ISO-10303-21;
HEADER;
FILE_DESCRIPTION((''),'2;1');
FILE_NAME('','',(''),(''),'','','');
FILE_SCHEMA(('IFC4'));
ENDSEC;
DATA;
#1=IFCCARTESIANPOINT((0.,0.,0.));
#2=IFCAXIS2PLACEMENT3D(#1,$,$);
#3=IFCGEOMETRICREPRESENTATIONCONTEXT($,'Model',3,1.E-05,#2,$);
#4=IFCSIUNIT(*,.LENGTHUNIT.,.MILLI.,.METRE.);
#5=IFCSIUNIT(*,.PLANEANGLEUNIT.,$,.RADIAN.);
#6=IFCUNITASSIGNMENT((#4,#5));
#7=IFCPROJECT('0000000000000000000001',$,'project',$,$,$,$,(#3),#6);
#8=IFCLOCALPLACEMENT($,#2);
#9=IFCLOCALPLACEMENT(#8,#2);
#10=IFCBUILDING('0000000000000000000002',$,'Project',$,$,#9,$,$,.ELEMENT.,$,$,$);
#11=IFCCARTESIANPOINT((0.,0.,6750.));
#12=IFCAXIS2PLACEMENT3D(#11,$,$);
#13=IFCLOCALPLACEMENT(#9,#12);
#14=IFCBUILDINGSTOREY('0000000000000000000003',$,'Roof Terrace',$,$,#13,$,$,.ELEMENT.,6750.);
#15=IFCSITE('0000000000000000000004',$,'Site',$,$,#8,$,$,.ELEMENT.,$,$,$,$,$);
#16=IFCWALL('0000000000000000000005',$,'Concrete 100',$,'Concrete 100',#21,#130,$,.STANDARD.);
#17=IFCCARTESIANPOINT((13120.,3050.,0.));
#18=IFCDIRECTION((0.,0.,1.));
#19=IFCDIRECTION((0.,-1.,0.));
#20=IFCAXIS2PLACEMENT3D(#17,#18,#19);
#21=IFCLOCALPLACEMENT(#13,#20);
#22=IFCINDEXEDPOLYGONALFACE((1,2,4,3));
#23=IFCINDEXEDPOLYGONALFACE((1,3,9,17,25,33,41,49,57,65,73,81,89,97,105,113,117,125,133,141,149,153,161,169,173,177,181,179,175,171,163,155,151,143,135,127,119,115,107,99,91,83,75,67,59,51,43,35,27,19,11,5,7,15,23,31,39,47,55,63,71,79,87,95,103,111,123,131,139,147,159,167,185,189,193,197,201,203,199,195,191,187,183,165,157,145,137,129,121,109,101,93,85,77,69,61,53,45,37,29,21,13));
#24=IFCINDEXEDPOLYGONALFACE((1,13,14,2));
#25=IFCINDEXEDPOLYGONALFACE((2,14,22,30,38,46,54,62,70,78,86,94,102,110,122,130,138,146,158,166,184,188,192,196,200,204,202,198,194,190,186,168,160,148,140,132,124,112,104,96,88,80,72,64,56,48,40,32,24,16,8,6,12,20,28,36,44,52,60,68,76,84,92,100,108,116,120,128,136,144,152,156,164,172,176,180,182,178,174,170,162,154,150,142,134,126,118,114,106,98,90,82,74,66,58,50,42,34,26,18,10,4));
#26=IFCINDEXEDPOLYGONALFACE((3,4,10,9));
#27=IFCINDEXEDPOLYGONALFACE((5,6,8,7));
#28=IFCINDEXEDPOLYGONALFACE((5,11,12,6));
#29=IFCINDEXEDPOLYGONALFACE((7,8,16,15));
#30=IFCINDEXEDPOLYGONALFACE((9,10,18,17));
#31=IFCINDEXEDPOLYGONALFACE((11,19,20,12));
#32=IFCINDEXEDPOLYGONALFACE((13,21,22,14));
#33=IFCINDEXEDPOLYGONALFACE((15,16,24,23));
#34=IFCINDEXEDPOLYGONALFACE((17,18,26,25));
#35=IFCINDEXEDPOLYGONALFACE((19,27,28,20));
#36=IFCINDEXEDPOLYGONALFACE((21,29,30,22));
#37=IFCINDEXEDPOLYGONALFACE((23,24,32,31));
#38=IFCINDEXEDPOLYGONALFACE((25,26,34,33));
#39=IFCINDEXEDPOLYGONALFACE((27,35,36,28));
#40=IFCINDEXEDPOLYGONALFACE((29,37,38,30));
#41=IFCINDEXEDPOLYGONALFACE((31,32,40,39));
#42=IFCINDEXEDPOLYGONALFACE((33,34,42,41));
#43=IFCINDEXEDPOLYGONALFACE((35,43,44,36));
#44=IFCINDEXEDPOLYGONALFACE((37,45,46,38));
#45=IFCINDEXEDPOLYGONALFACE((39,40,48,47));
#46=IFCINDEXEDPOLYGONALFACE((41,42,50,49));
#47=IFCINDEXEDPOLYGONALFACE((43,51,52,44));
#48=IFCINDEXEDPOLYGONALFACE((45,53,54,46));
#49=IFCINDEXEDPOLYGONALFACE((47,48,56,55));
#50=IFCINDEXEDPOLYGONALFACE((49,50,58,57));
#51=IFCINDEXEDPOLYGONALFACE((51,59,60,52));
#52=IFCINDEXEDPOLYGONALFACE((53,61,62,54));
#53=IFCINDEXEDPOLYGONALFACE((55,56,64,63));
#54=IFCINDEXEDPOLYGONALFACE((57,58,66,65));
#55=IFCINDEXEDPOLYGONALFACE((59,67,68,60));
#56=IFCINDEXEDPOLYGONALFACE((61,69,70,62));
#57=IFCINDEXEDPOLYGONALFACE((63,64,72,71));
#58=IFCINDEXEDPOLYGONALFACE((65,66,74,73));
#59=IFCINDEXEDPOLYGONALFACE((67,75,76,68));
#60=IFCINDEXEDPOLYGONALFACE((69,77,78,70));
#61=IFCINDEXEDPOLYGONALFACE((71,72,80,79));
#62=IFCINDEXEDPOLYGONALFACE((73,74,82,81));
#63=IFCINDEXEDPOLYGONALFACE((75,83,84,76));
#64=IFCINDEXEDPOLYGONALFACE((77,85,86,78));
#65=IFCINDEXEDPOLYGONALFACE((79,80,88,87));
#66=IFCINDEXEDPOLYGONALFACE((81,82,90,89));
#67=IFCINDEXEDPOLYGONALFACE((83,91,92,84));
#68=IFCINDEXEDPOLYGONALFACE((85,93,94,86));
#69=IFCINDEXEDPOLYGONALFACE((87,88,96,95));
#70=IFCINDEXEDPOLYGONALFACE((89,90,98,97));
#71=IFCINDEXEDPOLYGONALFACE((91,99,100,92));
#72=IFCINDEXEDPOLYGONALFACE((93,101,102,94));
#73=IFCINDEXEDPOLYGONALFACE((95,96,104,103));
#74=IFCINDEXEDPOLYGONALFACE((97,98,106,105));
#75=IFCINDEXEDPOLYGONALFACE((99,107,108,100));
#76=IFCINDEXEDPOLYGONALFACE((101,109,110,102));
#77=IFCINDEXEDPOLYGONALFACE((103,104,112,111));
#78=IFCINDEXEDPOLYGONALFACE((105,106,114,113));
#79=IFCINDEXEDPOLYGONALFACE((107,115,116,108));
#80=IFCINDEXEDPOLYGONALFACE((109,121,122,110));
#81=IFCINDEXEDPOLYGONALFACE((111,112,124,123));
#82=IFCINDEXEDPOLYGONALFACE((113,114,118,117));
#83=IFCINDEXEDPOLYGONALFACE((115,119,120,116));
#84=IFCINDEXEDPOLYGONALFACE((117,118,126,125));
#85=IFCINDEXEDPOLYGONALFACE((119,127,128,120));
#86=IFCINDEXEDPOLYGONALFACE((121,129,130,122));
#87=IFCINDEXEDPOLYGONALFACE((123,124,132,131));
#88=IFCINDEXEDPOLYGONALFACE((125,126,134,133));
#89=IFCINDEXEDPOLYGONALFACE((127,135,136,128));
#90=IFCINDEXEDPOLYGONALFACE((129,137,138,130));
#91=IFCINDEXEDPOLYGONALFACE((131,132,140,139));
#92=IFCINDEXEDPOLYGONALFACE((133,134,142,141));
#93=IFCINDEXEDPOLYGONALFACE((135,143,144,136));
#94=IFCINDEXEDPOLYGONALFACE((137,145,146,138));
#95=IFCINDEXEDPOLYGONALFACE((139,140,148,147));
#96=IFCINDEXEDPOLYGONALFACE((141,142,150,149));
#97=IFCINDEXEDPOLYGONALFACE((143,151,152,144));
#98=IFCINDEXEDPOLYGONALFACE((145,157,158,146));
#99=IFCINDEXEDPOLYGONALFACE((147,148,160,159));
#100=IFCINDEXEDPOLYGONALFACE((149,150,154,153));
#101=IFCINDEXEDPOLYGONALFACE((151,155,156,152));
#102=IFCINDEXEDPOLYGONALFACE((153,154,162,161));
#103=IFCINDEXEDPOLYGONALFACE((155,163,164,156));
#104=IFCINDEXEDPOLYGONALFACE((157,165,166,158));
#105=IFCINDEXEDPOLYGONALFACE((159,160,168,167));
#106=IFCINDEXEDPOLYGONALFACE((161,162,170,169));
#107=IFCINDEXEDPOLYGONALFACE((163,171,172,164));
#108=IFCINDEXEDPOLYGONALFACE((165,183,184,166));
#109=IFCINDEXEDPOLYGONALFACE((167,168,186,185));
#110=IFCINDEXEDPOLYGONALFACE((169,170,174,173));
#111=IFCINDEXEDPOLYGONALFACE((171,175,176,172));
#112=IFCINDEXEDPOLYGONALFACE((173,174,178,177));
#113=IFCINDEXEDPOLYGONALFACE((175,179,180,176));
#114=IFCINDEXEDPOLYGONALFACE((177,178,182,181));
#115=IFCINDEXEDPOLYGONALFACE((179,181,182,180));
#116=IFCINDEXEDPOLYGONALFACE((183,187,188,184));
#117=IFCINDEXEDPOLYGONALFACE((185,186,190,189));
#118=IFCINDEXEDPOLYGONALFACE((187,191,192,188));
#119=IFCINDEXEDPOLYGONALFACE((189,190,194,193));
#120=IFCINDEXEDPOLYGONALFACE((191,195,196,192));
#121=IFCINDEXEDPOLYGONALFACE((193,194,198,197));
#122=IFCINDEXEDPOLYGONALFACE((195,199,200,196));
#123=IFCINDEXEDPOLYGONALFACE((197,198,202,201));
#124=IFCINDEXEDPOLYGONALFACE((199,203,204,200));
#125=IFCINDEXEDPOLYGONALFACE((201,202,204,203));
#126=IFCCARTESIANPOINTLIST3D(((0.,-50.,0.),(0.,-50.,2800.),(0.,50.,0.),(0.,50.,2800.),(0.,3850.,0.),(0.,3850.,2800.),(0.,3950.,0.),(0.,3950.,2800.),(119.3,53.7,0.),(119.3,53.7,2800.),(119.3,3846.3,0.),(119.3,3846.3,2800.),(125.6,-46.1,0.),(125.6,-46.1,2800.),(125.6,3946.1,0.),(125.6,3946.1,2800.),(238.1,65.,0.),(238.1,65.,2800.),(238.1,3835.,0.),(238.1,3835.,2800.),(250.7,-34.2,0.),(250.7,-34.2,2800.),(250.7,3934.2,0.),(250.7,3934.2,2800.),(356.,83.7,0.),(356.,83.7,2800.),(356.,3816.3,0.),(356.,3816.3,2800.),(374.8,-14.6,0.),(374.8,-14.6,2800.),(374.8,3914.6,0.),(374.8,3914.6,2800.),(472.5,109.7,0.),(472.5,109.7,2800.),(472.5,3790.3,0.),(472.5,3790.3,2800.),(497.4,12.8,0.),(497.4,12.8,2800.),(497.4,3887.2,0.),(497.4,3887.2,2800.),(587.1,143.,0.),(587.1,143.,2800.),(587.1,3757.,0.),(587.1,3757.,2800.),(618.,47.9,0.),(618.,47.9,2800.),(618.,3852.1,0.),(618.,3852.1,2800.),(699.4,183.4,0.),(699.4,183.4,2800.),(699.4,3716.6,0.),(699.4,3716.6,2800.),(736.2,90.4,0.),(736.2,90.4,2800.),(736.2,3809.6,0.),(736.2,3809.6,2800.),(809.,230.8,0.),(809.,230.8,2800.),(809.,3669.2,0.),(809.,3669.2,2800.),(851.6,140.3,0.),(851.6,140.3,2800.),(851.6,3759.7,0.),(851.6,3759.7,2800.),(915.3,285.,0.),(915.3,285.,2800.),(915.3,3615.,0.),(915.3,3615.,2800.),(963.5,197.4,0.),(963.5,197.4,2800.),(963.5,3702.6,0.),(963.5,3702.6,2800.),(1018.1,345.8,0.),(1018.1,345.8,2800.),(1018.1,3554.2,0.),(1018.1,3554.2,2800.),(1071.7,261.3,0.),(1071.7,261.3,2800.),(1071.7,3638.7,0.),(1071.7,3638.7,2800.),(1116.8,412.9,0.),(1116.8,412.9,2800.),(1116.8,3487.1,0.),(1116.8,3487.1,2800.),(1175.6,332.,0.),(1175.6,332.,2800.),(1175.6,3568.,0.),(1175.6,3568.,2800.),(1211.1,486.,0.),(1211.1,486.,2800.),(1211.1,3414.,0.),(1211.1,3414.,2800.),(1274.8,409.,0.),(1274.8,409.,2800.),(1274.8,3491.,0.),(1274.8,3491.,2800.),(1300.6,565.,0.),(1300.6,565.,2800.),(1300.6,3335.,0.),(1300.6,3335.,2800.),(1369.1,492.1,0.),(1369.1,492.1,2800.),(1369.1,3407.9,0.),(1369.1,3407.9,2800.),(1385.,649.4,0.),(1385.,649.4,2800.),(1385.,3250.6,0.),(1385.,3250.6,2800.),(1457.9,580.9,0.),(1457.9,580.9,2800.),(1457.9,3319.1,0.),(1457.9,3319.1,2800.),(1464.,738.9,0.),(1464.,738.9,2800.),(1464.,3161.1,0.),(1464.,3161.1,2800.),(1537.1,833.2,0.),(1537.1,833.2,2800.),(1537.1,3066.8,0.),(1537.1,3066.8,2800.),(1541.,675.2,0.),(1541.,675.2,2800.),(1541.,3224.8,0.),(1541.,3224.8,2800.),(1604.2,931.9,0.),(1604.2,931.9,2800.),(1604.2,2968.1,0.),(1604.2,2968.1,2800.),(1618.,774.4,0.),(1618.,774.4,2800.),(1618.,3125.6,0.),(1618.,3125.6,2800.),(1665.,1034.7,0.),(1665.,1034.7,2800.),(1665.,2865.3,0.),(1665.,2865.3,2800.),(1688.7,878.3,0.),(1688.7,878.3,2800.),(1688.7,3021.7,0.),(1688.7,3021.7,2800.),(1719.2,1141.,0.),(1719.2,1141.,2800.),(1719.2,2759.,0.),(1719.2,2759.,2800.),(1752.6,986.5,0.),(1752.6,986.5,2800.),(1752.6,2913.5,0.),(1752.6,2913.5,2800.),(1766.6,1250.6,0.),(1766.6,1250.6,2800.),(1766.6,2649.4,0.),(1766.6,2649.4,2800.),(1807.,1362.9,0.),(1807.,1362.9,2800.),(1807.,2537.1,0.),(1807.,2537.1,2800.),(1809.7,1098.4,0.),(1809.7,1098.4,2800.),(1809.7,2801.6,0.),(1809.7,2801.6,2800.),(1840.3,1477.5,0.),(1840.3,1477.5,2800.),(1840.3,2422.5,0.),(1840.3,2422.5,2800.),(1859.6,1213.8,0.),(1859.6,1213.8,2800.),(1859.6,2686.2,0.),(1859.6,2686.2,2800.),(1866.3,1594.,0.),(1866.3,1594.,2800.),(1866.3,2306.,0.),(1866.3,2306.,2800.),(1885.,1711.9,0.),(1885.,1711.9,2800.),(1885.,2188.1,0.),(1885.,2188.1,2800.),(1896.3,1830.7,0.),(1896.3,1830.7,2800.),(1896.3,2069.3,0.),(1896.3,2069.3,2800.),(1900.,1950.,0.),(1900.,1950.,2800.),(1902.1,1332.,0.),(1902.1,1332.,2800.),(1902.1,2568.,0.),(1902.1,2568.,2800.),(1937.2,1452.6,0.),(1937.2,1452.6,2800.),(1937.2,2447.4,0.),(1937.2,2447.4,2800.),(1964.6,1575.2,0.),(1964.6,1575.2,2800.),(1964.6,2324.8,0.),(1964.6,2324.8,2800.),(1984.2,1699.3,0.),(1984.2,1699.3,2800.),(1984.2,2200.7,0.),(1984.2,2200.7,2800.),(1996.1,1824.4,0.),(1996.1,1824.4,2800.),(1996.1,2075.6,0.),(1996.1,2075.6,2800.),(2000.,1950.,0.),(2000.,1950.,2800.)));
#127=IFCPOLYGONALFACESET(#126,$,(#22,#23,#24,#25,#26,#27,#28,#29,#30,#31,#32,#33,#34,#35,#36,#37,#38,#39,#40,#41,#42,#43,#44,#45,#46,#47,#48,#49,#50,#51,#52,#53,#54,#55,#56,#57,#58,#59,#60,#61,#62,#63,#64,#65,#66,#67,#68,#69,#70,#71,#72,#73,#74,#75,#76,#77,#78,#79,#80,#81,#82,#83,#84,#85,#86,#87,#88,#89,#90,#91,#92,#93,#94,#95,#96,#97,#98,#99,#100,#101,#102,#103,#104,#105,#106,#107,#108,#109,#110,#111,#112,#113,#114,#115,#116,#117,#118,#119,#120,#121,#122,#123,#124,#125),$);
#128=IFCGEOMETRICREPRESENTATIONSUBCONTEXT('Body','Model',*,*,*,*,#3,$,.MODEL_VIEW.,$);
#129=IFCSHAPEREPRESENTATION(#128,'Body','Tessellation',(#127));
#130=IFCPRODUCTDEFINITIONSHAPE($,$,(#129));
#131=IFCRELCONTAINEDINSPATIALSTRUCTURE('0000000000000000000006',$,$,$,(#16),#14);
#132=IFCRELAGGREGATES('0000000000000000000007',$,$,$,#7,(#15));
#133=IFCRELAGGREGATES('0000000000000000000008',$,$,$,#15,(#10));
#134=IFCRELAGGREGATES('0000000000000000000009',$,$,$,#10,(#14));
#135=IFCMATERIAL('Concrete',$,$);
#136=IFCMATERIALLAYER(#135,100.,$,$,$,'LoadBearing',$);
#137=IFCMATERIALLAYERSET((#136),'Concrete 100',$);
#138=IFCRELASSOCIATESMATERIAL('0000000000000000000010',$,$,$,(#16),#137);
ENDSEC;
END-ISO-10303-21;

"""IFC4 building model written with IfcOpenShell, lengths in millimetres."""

from ifc_helpers import new_model, si_unit, frame, origin, place, context, subcontext, project, spatial, polyline, outline, extrude, material, layer, layer_set, layer_usage, element, save


model = new_model("IFC4")

# Units and contexts
model_context = context("Model", 3, precision=1e-05, world=origin())
body_context = subcontext(model_context, "Body", "Model", "MODEL_VIEW")
ifc_project = project(units=[si_unit("LENGTHUNIT", "METRE", prefix="MILLI"), si_unit("PLANEANGLEUNIT", "RADIAN")], contexts=[model_context])

# Site, building, storey
site_placement = place(None, origin())
site = spatial("IfcSite", under=ifc_project, at=site_placement, Name="Site", CompositionType="ELEMENT")
building_placement = place(site_placement, origin())
building = spatial("IfcBuilding", under=site, at=building_placement, Name="Project", CompositionType="ELEMENT")
storey_placement = place(building_placement, frame((0.0, 0.0, 6750.0)))
storey = spatial("IfcBuildingStorey", under=building, at=storey_placement, Name="Roof Terrace", CompositionType="ELEMENT", Elevation=6750.0)

# Shared definitions
ifc_material = material(Name="Concrete")

# Wall
ifc_layer_1 = layer(ifc_material, 100.0, Category="LoadBearing")
ifc_layer_set_1 = layer_set([ifc_layer_1], Name="Concrete 100")
ifc_layer_usage_1 = layer_usage(ifc_layer_set_1, "AXIS2", "NEGATIVE", 50.0)
wall_1_placement = place(storey_placement, frame((13120.0, 3050.0, 0.0), z_axis=(0.0, 0.0, 1.0), x_axis=(0.0, -1.0, 0.0)))
element("IfcWall", 1, at=wall_1_placement, inside=storey, material=ifc_layer_usage_1, Name="Concrete 100", ObjectType="Concrete 100", PredefinedType="STANDARD", context=body_context, shape_type="SweptSolid", body=[
    extrude(outline(polyline([(0.0, -50.0), (0.0, 50.0), (119.3, 53.7), (238.1, 65.0), (356.0, 83.7), (472.5, 109.7), (587.1, 143.0), (699.4, 183.4), (809.0, 230.8), (915.3, 285.0), (1018.1, 345.8), (1116.8, 412.9), (1211.1, 486.0), (1300.6, 565.0), (1385.0, 649.4), (1464.0, 738.9), (1537.1, 833.2), (1604.2, 931.9), (1665.0, 1034.7), (1719.2, 1141.0), (1766.6, 1250.6), (1807.0, 1362.9), (1840.3, 1477.5), (1866.3, 1594.0), (1885.0, 1711.9), (1896.3, 1830.7), (1900.0, 1950.0), (1896.3, 2069.3), (1885.0, 2188.1), (1866.3, 2306.0), (1840.3, 2422.5), (1807.0, 2537.1), (1766.6, 2649.4), (1719.2, 2759.0), (1665.0, 2865.3), (1604.2, 2968.1), (1537.1, 3066.8), (1464.0, 3161.1), (1385.0, 3250.6), (1300.6, 3335.0), (1211.1, 3414.0), (1116.8, 3487.1), (1018.1, 3554.2), (915.3, 3615.0), (809.0, 3669.2), (699.4, 3716.6), (587.1, 3757.0), (472.5, 3790.3), (356.0, 3816.3), (238.1, 3835.0), (119.3, 3846.3), (0.0, 3850.0), (0.0, 3950.0), (125.6, 3946.1), (250.7, 3934.2), (374.8, 3914.6), (497.4, 3887.2), (618.0, 3852.1), (736.2, 3809.6), (851.6, 3759.7), (963.5, 3702.6), (1071.7, 3638.7), (1175.6, 3568.0), (1274.8, 3491.0), (1369.1, 3407.9), (1457.9, 3319.1), (1541.0, 3224.8), (1618.0, 3125.6), (1688.7, 3021.7), (1752.6, 2913.5), (1809.7, 2801.6), (1859.6, 2686.2), (1902.1, 2568.0), (1937.2, 2447.4), (1964.6, 2324.8), (1984.2, 2200.7), (1996.1, 2075.6), (2000.0, 1950.0), (1996.1, 1824.4), (1984.2, 1699.3), (1964.6, 1575.2), (1937.2, 1452.6), (1902.1, 1332.0), (1859.6, 1213.8), (1809.7, 1098.4), (1752.6, 986.5), (1688.7, 878.3), (1618.0, 774.4), (1541.0, 675.2), (1457.9, 580.9), (1369.1, 492.1), (1274.8, 409.0), (1175.6, 332.0), (1071.7, 261.3), (963.5, 197.4), (851.6, 140.3), (736.2, 90.4), (618.0, 47.9), (497.4, 12.8), (374.8, -14.6), (250.7, -34.2), (125.6, -46.1), (0.0, -50.0)])), origin(), (0.0, 0.0, 1.0), 2800.0),
])

save(model, "model.ifc")
